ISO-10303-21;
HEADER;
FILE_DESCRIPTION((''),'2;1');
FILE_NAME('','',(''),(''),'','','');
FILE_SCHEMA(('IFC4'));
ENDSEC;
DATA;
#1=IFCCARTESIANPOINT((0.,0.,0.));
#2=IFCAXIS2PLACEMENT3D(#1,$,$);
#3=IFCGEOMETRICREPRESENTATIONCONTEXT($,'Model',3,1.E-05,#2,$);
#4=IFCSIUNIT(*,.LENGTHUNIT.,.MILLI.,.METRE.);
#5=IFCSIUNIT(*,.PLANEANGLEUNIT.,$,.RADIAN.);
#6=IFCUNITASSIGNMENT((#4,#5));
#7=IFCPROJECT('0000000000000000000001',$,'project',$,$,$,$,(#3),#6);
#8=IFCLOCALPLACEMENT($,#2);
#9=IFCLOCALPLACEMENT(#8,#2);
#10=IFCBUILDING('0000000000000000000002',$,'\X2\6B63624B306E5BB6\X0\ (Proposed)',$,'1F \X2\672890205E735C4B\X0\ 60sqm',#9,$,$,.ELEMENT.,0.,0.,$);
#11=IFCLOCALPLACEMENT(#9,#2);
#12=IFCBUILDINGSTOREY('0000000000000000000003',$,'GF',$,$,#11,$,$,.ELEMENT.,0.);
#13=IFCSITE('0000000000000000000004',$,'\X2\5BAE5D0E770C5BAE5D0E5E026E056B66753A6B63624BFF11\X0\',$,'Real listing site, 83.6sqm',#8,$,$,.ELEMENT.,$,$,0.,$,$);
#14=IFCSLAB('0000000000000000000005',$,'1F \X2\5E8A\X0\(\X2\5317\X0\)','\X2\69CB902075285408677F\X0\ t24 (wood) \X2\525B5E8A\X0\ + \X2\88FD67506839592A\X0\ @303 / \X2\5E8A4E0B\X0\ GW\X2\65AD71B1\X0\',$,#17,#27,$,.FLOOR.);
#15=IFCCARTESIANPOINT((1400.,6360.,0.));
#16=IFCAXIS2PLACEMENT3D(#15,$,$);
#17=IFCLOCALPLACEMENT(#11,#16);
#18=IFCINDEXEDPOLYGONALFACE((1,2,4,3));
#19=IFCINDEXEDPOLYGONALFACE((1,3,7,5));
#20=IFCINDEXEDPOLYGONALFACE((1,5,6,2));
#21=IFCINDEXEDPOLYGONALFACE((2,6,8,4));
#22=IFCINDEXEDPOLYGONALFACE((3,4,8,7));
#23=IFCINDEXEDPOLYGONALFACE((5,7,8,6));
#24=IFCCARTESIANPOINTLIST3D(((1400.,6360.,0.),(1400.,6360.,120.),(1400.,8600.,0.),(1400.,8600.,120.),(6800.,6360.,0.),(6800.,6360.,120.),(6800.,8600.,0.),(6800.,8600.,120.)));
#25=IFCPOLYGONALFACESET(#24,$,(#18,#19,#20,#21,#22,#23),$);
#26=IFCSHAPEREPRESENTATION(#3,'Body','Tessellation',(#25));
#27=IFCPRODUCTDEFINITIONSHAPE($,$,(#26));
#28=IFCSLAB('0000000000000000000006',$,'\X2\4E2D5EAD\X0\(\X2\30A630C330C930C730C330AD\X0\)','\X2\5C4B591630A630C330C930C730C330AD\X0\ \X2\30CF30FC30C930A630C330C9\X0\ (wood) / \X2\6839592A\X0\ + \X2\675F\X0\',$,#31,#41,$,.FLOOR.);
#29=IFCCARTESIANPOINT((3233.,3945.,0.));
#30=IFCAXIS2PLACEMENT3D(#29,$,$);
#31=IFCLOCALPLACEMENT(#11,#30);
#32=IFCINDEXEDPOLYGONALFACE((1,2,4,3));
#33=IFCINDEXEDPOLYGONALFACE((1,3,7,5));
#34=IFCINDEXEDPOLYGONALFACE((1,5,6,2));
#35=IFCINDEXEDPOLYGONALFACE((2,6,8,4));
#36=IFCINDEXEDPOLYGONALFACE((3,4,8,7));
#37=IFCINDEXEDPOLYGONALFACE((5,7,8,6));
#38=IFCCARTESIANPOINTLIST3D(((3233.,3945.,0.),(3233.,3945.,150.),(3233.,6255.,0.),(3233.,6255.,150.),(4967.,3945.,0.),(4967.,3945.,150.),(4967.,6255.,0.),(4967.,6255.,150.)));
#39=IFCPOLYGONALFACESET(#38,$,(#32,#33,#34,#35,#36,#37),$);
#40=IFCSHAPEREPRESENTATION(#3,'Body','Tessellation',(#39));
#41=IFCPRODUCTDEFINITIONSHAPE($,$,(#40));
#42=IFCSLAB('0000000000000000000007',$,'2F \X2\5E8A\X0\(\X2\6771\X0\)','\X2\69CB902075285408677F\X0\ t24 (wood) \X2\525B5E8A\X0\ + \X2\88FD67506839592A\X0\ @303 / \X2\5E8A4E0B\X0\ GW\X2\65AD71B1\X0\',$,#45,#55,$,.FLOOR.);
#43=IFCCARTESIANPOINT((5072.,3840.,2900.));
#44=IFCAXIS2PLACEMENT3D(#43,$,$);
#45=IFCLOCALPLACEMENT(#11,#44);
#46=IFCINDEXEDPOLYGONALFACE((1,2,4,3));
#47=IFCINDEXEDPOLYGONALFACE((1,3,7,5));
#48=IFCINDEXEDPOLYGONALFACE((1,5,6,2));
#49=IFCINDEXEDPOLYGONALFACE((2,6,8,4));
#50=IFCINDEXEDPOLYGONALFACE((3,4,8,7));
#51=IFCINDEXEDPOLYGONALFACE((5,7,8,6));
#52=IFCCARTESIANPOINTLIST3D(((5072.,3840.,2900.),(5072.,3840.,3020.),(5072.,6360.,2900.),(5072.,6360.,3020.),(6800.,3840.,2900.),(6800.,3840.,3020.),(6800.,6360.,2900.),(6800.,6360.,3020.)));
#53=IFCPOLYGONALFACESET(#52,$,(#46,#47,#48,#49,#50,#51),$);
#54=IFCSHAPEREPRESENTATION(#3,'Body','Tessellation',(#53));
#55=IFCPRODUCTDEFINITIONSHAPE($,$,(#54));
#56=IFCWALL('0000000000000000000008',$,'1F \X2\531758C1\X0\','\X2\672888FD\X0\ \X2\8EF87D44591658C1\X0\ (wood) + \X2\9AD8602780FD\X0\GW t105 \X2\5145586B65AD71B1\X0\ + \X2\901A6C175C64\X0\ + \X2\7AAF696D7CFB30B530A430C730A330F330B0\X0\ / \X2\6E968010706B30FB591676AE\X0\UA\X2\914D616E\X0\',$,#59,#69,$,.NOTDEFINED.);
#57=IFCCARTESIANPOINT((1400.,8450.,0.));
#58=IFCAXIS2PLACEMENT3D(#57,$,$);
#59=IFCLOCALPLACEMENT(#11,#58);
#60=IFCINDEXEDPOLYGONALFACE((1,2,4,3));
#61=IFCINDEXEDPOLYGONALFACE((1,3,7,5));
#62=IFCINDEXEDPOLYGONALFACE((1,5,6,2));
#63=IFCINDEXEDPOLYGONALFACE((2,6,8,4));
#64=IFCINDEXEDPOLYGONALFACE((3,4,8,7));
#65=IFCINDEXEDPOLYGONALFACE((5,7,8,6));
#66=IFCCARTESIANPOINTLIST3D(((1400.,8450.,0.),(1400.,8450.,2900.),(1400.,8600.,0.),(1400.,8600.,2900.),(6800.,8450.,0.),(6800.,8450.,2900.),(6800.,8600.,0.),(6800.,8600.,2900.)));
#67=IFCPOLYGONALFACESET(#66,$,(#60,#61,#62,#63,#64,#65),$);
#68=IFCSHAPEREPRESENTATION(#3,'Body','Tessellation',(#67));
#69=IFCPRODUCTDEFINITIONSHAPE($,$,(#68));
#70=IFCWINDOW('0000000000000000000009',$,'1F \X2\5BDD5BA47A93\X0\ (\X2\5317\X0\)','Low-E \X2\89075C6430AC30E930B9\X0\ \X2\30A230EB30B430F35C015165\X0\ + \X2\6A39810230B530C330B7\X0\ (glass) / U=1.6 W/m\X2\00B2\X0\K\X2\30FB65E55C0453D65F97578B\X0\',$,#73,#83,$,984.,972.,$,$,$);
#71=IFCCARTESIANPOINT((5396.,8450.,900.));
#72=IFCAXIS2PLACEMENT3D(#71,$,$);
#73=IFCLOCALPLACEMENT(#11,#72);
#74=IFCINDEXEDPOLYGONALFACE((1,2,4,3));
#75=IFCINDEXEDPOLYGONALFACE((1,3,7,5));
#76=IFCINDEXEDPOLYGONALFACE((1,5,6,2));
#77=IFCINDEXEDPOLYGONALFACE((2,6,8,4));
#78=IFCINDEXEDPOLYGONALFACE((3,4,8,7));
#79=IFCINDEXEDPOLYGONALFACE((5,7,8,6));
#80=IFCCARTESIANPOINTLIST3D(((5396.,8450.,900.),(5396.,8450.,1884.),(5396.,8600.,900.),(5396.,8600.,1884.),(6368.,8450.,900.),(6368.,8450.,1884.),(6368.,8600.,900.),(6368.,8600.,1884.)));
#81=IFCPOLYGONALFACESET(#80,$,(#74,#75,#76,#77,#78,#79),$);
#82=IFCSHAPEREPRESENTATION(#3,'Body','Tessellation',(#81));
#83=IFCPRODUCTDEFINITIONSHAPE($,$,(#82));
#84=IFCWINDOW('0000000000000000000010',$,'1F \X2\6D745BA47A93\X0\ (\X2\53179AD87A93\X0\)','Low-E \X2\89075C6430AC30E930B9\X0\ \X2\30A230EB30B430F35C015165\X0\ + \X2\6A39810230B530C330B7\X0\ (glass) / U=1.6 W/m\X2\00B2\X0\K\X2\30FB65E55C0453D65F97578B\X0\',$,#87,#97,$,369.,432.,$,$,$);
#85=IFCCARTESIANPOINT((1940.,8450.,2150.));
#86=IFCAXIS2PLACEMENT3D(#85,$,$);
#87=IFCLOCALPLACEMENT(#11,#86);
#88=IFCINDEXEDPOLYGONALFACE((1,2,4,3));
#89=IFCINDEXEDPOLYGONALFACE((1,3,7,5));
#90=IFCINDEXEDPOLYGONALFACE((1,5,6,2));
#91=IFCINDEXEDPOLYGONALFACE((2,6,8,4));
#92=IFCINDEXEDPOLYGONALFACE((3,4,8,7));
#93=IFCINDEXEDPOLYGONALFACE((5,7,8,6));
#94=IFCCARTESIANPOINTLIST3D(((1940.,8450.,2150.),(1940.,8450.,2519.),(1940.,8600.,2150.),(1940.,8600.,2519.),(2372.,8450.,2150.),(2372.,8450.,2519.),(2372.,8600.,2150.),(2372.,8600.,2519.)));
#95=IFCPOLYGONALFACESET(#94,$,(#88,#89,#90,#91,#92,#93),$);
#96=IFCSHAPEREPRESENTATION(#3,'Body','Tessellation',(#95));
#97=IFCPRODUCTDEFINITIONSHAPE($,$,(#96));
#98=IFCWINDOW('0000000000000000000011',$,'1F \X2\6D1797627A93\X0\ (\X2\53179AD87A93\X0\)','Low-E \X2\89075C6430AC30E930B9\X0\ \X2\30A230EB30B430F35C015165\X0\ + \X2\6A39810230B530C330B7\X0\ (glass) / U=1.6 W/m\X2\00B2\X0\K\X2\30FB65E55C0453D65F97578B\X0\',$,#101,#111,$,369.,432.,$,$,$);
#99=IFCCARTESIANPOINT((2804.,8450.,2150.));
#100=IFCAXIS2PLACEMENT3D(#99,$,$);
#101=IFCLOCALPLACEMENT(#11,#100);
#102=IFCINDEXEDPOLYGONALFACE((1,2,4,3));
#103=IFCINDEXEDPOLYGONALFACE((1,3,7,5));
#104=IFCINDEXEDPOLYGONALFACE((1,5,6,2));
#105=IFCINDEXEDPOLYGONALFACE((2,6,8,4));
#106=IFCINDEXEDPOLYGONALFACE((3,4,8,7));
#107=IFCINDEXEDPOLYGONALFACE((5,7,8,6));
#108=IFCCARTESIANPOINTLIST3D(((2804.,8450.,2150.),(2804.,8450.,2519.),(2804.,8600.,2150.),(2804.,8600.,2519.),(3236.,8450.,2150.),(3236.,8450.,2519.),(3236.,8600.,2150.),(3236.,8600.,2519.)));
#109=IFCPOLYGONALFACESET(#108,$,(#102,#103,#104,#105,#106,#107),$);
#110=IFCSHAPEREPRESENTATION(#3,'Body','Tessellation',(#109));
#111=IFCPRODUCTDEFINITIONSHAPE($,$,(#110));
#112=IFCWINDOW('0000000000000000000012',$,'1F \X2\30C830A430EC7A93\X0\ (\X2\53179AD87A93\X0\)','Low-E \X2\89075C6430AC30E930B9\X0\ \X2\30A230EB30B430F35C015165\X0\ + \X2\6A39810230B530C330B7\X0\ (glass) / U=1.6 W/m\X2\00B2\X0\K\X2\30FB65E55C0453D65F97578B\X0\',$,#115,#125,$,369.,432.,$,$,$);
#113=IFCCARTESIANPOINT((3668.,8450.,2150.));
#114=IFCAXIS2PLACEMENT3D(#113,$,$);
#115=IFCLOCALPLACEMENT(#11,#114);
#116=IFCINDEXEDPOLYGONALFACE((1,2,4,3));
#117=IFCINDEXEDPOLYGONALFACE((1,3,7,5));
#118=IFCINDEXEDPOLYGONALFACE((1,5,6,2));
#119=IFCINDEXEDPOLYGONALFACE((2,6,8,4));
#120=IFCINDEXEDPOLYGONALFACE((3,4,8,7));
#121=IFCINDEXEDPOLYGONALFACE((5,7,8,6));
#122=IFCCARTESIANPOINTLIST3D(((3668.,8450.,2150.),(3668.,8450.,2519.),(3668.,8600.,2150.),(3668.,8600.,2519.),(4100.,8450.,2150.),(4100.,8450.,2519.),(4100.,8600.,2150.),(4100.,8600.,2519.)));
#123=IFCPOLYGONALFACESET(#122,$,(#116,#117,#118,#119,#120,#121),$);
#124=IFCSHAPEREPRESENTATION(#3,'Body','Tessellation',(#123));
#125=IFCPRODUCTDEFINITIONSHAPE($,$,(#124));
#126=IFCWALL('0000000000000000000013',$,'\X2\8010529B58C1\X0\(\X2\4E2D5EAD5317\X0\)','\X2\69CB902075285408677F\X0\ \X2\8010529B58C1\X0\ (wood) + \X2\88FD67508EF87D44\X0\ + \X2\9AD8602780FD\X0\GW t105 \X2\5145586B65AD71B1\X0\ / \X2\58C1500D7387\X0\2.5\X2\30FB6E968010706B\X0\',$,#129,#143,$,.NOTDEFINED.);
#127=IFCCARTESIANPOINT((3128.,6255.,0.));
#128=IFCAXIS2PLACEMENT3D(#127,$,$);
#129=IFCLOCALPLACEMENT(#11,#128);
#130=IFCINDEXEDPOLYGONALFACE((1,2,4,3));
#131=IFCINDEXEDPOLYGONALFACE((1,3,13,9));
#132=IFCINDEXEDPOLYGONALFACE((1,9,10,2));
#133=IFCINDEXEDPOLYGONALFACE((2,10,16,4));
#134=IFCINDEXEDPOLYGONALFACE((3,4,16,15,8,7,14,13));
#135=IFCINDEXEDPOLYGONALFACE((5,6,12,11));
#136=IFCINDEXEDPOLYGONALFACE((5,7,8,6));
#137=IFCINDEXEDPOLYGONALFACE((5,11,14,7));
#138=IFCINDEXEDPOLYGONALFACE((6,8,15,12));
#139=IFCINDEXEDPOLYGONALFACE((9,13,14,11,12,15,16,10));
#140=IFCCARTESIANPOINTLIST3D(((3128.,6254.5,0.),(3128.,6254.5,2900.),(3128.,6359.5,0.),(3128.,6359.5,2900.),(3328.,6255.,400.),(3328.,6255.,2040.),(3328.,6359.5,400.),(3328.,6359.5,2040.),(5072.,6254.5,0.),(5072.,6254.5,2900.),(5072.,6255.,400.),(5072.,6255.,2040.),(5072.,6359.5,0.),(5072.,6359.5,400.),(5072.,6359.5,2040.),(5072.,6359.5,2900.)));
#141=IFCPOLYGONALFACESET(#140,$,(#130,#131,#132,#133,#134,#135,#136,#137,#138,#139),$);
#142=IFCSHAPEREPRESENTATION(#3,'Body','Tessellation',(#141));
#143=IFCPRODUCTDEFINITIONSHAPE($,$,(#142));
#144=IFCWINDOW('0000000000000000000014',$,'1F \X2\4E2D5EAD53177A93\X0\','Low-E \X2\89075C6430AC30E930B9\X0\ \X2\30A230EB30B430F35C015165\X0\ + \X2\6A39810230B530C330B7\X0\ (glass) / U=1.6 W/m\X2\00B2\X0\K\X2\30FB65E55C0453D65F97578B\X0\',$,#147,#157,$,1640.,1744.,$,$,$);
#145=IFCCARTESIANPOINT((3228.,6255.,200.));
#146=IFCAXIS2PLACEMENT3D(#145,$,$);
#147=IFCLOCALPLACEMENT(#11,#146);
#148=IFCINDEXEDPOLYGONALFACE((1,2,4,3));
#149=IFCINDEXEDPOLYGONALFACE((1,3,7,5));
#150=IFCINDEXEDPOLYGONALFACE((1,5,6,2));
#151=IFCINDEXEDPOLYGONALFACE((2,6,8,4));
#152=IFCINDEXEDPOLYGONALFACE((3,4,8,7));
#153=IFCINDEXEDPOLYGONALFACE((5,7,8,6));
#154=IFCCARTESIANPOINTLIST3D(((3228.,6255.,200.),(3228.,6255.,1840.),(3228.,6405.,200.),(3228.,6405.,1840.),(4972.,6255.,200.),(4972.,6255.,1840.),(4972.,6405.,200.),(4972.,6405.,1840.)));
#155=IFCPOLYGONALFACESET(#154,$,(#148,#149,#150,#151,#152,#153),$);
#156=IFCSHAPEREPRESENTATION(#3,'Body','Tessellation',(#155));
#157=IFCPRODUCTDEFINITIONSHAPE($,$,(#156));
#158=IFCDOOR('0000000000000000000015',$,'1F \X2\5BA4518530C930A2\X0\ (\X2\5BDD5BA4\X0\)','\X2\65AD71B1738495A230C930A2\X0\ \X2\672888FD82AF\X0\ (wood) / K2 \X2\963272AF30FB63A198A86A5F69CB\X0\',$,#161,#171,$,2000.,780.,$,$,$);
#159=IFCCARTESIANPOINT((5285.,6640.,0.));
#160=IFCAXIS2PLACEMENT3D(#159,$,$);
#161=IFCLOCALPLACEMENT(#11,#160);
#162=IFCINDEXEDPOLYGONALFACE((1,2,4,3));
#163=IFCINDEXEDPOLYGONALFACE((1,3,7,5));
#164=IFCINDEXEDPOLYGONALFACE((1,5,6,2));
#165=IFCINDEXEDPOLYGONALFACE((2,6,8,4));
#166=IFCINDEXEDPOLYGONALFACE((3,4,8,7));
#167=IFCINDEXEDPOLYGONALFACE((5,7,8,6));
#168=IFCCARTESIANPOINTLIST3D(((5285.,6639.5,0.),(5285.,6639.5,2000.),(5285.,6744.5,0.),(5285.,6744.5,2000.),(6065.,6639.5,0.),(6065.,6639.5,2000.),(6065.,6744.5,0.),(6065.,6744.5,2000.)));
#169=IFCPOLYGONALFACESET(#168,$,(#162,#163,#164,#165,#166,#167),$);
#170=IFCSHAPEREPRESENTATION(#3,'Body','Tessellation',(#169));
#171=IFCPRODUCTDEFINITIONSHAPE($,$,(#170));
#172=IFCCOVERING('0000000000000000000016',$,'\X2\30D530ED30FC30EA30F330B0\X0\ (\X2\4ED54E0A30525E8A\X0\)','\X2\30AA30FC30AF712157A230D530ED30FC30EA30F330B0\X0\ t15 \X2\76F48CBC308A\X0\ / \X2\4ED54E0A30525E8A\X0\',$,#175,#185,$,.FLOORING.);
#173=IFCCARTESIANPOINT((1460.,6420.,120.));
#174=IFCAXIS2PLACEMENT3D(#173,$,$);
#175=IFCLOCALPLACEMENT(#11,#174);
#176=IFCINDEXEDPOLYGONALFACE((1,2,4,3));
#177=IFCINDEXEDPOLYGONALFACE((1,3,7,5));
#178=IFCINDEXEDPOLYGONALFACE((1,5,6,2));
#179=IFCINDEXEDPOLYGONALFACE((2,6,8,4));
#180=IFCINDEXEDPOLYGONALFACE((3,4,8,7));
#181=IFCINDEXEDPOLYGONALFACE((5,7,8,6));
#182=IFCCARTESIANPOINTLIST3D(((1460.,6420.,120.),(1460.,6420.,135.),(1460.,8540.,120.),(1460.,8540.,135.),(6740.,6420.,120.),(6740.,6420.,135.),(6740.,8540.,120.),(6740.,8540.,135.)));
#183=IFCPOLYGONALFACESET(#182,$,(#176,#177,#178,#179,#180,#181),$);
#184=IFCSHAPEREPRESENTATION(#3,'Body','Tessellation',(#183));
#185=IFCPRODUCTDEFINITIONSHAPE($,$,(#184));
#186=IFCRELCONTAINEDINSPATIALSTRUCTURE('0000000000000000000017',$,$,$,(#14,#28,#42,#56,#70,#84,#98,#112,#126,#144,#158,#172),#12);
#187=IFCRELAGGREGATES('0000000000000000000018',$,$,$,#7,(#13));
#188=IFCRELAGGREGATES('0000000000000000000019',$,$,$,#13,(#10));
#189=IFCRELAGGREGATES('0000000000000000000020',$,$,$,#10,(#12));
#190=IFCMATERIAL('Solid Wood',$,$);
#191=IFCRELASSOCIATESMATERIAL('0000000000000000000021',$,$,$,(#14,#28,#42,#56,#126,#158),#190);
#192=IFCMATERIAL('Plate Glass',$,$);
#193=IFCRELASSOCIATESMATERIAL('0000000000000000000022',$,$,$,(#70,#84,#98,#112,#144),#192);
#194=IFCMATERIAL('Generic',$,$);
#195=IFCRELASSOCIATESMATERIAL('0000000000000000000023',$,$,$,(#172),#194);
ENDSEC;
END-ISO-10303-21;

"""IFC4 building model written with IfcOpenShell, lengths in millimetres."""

from ifc_helpers import new_model, si_unit, frame, frame_2d, origin, place, context, project, spatial, rectangle, extrude, material, element, fill, save


model = new_model("IFC4")

# Units and contexts
model_context = context("Model", 3, precision=1e-05, world=origin())
ifc_project = project(units=[si_unit("LENGTHUNIT", "METRE", prefix="MILLI"), si_unit("PLANEANGLEUNIT", "RADIAN")], contexts=[model_context])

# Site, building, storey
site_placement = place(None, origin())
site = spatial("IfcSite", under=ifc_project, at=site_placement, Name="宮崎県宮崎市清武町正手１", ObjectType="Real listing site, 83.6sqm", CompositionType="ELEMENT", RefElevation=0.0)
building_placement = place(site_placement, origin())
building = spatial("IfcBuilding", under=site, at=building_placement, Name="正手の家 (Proposed)", ObjectType="1F 木造平屋 60sqm", CompositionType="ELEMENT", ElevationOfRefHeight=0.0, ElevationOfTerrain=0.0)
storey_placement = place(building_placement, origin())
storey = spatial("IfcBuildingStorey", under=building, at=storey_placement, Name="GF", CompositionType="ELEMENT", Elevation=0.0)

# Slabs
ifc_material_1 = material(Name="Solid Wood")
slab_1_placement = place(storey_placement, frame((1400.0, 6360.0, 0.0)))
element("IfcSlab", 1, at=slab_1_placement, inside=storey, material=ifc_material_1, Name="1F 床(北)", Description="構造用合板 t24 (wood) 剛床 + 製材根太 @303 / 床下 GW断熱", PredefinedType="FLOOR", context=model_context, shape_type="SweptSolid", body=[
    extrude(rectangle(XDim=5400.0, YDim=2240.0, at=frame_2d((2700.0, 1120.0))), frame((1400.0, 6360.0, 0.0)), (0.0, 0.0, 1.0), 120.0),
])
slab_2_placement = place(storey_placement, frame((3233.0, 3945.0, 0.0)))
element("IfcSlab", 2, at=slab_2_placement, inside=storey, material=ifc_material_1, Name="中庭(ウッドデッキ)", Description="屋外ウッドデッキ ハードウッド (wood) / 根太 + 束", PredefinedType="FLOOR", context=model_context, shape_type="SweptSolid", body=[
    extrude(rectangle(XDim=1734.0, YDim=2310.0, at=frame_2d((867.0, 1155.0))), frame((3233.0, 3945.0, 0.0)), (0.0, 0.0, 1.0), 150.0),
])
slab_3_placement = place(storey_placement, frame((5072.0, 3840.0, 2900.0)))
element("IfcSlab", 3, at=slab_3_placement, inside=storey, material=ifc_material_1, Name="2F 床(東)", Description="構造用合板 t24 (wood) 剛床 + 製材根太 @303 / 床下 GW断熱", PredefinedType="FLOOR", context=model_context, shape_type="SweptSolid", body=[
    extrude(rectangle(XDim=1728.0, YDim=2520.0, at=frame_2d((864.0, 1260.0))), frame((5072.0, 3840.0, 2900.0)), (0.0, 0.0, 1.0), 120.0),
])

# Wall, openings, windows
wall_1_placement = place(storey_placement, frame((1400.0, 8450.0, 0.0)))
wall_1 = element("IfcWall", 4, at=wall_1_placement, inside=storey, material=ifc_material_1, Name="1F 北壁", Description="木製 軸組外壁 (wood) + 高性能GW t105 充填断熱 + 通気層 + 窯業系サイディング / 準耐火・外皮UA配慮", PredefinedType="NOTDEFINED", context=model_context, shape_type="SweptSolid", body=[
    extrude(rectangle(XDim=5400.0, YDim=150.0, at=frame_2d((2700.0, 75.0))), frame((1400.0, 8450.0, 0.0)), (0.0, 0.0, 1.0), 2900.0),
])
opening_1_placement = place(storey_placement, frame((5396.0, 8450.0, 900.0)))
opening_1 = element("IfcOpeningElement", 5, at=opening_1_placement, cuts=wall_1, PredefinedType="NOTDEFINED", context=model_context, shape_type="SweptSolid", body=[
    extrude(rectangle(XDim=972.0, YDim=150.0, at=frame_2d((486.0, 75.0))), frame((5396.0, 8450.0, 900.0)), (0.0, 0.0, 1.0), 984.0),
])
opening_2_placement = place(storey_placement, frame((1940.0, 8450.0, 2150.0)))
opening_2 = element("IfcOpeningElement", 6, at=opening_2_placement, cuts=wall_1, PredefinedType="NOTDEFINED", context=model_context, shape_type="SweptSolid", body=[
    extrude(rectangle(XDim=432.0, YDim=150.0, at=frame_2d((216.0, 75.0))), frame((1940.0, 8450.0, 2150.0)), (0.0, 0.0, 1.0), 369.0),
])
opening_3_placement = place(storey_placement, frame((2804.0, 8450.0, 2150.0)))
opening_3 = element("IfcOpeningElement", 7, at=opening_3_placement, cuts=wall_1, PredefinedType="NOTDEFINED", context=model_context, shape_type="SweptSolid", body=[
    extrude(rectangle(XDim=432.0, YDim=150.0, at=frame_2d((216.0, 75.0))), frame((2804.0, 8450.0, 2150.0)), (0.0, 0.0, 1.0), 369.0),
])
opening_4_placement = place(storey_placement, frame((3668.0, 8450.0, 2150.0)))
opening_4 = element("IfcOpeningElement", 8, at=opening_4_placement, cuts=wall_1, PredefinedType="NOTDEFINED", context=model_context, shape_type="SweptSolid", body=[
    extrude(rectangle(XDim=432.0, YDim=150.0, at=frame_2d((216.0, 75.0))), frame((3668.0, 8450.0, 2150.0)), (0.0, 0.0, 1.0), 369.0),
])
ifc_material_2 = material(Name="Plate Glass")
window_1_placement = place(storey_placement, frame((5396.0, 8450.0, 900.0)))
window_1 = element("IfcWindow", 9, at=window_1_placement, inside=storey, material=ifc_material_2, Name="1F 寝室窓 (北)", Description="Low-E 複層ガラス アルゴン封入 + 樹脂サッシ (glass) / U=1.6 W/m²K・日射取得型", OverallHeight=984.0, OverallWidth=972.0, context=model_context, shape_type="SweptSolid", body=[
    extrude(rectangle(XDim=972.0, YDim=150.0, at=frame_2d((486.0, 75.0))), frame((5396.0, 8450.0, 900.0)), (0.0, 0.0, 1.0), 984.0),
])
fill(opening_1, window_1)
window_2_placement = place(storey_placement, frame((1940.0, 8450.0, 2150.0)))
window_2 = element("IfcWindow", 10, at=window_2_placement, inside=storey, material=ifc_material_2, Name="1F 浴室窓 (北高窓)", Description="Low-E 複層ガラス アルゴン封入 + 樹脂サッシ (glass) / U=1.6 W/m²K・日射取得型", OverallHeight=369.0, OverallWidth=432.0, context=model_context, shape_type="SweptSolid", body=[
    extrude(rectangle(XDim=432.0, YDim=150.0, at=frame_2d((216.0, 75.0))), frame((1940.0, 8450.0, 2150.0)), (0.0, 0.0, 1.0), 369.0),
])
fill(opening_2, window_2)
window_3_placement = place(storey_placement, frame((2804.0, 8450.0, 2150.0)))
window_3 = element("IfcWindow", 11, at=window_3_placement, inside=storey, material=ifc_material_2, Name="1F 洗面窓 (北高窓)", Description="Low-E 複層ガラス アルゴン封入 + 樹脂サッシ (glass) / U=1.6 W/m²K・日射取得型", OverallHeight=369.0, OverallWidth=432.0, context=model_context, shape_type="SweptSolid", body=[
    extrude(rectangle(XDim=432.0, YDim=150.0, at=frame_2d((216.0, 75.0))), frame((2804.0, 8450.0, 2150.0)), (0.0, 0.0, 1.0), 369.0),
])
fill(opening_3, window_3)
window_4_placement = place(storey_placement, frame((3668.0, 8450.0, 2150.0)))
window_4 = element("IfcWindow", 12, at=window_4_placement, inside=storey, material=ifc_material_2, Name="1F トイレ窓 (北高窓)", Description="Low-E 複層ガラス アルゴン封入 + 樹脂サッシ (glass) / U=1.6 W/m²K・日射取得型", OverallHeight=369.0, OverallWidth=432.0, context=model_context, shape_type="SweptSolid", body=[
    extrude(rectangle(XDim=432.0, YDim=150.0, at=frame_2d((216.0, 75.0))), frame((3668.0, 8450.0, 2150.0)), (0.0, 0.0, 1.0), 369.0),
])
fill(opening_4, window_4)

# Wall, opening, window
wall_2_placement = place(storey_placement, frame((3128.0, 6255.0, 0.0)))
wall_2 = element("IfcWall", 13, at=wall_2_placement, inside=storey, material=ifc_material_1, Name="耐力壁(中庭北)", Description="構造用合板 耐力壁 (wood) + 製材軸組 + 高性能GW t105 充填断熱 / 壁倍率2.5・準耐火", PredefinedType="NOTDEFINED", context=model_context, shape_type="SweptSolid", body=[
    extrude(rectangle(XDim=1944.0, YDim=105.0, at=frame_2d((972.0, 52.0))), frame((3128.0, 6255.0, 0.0)), (0.0, 0.0, 1.0), 2900.0),
])
opening_5_placement = place(storey_placement, frame((3228.0, 6255.0, 200.0)))
opening_5 = element("IfcOpeningElement", 14, at=opening_5_placement, cuts=wall_2, PredefinedType="NOTDEFINED", context=model_context, shape_type="SweptSolid", body=[
    extrude(rectangle(XDim=1744.0, YDim=150.0, at=frame_2d((872.0, 75.0))), frame((3228.0, 6255.0, 200.0)), (0.0, 0.0, 1.0), 1640.0),
])
window_5_placement = place(storey_placement, frame((3228.0, 6255.0, 200.0)))
window_5 = element("IfcWindow", 15, at=window_5_placement, inside=storey, material=ifc_material_2, Name="1F 中庭北窓", Description="Low-E 複層ガラス アルゴン封入 + 樹脂サッシ (glass) / U=1.6 W/m²K・日射取得型", OverallHeight=1640.0, OverallWidth=1744.0, context=model_context, shape_type="SweptSolid", body=[
    extrude(rectangle(XDim=1744.0, YDim=150.0, at=frame_2d((872.0, 75.0))), frame((3228.0, 6255.0, 200.0)), (0.0, 0.0, 1.0), 1640.0),
])
fill(opening_5, window_5)

# Door
door_1_placement = place(storey_placement, frame((5285.0, 6640.0, 0.0)))
element("IfcDoor", 16, at=door_1_placement, inside=storey, material=ifc_material_1, Name="1F 室内ドア (寝室)", Description="断熱玄関ドア 木製芯 (wood) / K2 防犯・採風機構", OverallHeight=2000.0, OverallWidth=780.0, context=model_context, shape_type="SweptSolid", body=[
    extrude(rectangle(XDim=780.0, YDim=105.0, at=frame_2d((390.0, 52.0))), frame((5285.0, 6640.0, 0.0)), (0.0, 0.0, 1.0), 2000.0),
])

# Covering
ifc_material_3 = material(Name="Generic")
covering_1_placement = place(storey_placement, frame((1460.0, 6420.0, 120.0)))
element("IfcCovering", 17, at=covering_1_placement, inside=storey, material=ifc_material_3, Name="フローリング (仕上げ床)", Description="オーク無垢フローリング t15 直貼り / 仕上げ床", PredefinedType="FLOORING", context=model_context, shape_type="SweptSolid", body=[
    extrude(rectangle(XDim=5280.0, YDim=2120.0, at=frame_2d((2640.0, 1060.0))), frame((1460.0, 6420.0, 120.0)), (0.0, 0.0, 1.0), 15.0),
])

save(model, "model.ifc")
